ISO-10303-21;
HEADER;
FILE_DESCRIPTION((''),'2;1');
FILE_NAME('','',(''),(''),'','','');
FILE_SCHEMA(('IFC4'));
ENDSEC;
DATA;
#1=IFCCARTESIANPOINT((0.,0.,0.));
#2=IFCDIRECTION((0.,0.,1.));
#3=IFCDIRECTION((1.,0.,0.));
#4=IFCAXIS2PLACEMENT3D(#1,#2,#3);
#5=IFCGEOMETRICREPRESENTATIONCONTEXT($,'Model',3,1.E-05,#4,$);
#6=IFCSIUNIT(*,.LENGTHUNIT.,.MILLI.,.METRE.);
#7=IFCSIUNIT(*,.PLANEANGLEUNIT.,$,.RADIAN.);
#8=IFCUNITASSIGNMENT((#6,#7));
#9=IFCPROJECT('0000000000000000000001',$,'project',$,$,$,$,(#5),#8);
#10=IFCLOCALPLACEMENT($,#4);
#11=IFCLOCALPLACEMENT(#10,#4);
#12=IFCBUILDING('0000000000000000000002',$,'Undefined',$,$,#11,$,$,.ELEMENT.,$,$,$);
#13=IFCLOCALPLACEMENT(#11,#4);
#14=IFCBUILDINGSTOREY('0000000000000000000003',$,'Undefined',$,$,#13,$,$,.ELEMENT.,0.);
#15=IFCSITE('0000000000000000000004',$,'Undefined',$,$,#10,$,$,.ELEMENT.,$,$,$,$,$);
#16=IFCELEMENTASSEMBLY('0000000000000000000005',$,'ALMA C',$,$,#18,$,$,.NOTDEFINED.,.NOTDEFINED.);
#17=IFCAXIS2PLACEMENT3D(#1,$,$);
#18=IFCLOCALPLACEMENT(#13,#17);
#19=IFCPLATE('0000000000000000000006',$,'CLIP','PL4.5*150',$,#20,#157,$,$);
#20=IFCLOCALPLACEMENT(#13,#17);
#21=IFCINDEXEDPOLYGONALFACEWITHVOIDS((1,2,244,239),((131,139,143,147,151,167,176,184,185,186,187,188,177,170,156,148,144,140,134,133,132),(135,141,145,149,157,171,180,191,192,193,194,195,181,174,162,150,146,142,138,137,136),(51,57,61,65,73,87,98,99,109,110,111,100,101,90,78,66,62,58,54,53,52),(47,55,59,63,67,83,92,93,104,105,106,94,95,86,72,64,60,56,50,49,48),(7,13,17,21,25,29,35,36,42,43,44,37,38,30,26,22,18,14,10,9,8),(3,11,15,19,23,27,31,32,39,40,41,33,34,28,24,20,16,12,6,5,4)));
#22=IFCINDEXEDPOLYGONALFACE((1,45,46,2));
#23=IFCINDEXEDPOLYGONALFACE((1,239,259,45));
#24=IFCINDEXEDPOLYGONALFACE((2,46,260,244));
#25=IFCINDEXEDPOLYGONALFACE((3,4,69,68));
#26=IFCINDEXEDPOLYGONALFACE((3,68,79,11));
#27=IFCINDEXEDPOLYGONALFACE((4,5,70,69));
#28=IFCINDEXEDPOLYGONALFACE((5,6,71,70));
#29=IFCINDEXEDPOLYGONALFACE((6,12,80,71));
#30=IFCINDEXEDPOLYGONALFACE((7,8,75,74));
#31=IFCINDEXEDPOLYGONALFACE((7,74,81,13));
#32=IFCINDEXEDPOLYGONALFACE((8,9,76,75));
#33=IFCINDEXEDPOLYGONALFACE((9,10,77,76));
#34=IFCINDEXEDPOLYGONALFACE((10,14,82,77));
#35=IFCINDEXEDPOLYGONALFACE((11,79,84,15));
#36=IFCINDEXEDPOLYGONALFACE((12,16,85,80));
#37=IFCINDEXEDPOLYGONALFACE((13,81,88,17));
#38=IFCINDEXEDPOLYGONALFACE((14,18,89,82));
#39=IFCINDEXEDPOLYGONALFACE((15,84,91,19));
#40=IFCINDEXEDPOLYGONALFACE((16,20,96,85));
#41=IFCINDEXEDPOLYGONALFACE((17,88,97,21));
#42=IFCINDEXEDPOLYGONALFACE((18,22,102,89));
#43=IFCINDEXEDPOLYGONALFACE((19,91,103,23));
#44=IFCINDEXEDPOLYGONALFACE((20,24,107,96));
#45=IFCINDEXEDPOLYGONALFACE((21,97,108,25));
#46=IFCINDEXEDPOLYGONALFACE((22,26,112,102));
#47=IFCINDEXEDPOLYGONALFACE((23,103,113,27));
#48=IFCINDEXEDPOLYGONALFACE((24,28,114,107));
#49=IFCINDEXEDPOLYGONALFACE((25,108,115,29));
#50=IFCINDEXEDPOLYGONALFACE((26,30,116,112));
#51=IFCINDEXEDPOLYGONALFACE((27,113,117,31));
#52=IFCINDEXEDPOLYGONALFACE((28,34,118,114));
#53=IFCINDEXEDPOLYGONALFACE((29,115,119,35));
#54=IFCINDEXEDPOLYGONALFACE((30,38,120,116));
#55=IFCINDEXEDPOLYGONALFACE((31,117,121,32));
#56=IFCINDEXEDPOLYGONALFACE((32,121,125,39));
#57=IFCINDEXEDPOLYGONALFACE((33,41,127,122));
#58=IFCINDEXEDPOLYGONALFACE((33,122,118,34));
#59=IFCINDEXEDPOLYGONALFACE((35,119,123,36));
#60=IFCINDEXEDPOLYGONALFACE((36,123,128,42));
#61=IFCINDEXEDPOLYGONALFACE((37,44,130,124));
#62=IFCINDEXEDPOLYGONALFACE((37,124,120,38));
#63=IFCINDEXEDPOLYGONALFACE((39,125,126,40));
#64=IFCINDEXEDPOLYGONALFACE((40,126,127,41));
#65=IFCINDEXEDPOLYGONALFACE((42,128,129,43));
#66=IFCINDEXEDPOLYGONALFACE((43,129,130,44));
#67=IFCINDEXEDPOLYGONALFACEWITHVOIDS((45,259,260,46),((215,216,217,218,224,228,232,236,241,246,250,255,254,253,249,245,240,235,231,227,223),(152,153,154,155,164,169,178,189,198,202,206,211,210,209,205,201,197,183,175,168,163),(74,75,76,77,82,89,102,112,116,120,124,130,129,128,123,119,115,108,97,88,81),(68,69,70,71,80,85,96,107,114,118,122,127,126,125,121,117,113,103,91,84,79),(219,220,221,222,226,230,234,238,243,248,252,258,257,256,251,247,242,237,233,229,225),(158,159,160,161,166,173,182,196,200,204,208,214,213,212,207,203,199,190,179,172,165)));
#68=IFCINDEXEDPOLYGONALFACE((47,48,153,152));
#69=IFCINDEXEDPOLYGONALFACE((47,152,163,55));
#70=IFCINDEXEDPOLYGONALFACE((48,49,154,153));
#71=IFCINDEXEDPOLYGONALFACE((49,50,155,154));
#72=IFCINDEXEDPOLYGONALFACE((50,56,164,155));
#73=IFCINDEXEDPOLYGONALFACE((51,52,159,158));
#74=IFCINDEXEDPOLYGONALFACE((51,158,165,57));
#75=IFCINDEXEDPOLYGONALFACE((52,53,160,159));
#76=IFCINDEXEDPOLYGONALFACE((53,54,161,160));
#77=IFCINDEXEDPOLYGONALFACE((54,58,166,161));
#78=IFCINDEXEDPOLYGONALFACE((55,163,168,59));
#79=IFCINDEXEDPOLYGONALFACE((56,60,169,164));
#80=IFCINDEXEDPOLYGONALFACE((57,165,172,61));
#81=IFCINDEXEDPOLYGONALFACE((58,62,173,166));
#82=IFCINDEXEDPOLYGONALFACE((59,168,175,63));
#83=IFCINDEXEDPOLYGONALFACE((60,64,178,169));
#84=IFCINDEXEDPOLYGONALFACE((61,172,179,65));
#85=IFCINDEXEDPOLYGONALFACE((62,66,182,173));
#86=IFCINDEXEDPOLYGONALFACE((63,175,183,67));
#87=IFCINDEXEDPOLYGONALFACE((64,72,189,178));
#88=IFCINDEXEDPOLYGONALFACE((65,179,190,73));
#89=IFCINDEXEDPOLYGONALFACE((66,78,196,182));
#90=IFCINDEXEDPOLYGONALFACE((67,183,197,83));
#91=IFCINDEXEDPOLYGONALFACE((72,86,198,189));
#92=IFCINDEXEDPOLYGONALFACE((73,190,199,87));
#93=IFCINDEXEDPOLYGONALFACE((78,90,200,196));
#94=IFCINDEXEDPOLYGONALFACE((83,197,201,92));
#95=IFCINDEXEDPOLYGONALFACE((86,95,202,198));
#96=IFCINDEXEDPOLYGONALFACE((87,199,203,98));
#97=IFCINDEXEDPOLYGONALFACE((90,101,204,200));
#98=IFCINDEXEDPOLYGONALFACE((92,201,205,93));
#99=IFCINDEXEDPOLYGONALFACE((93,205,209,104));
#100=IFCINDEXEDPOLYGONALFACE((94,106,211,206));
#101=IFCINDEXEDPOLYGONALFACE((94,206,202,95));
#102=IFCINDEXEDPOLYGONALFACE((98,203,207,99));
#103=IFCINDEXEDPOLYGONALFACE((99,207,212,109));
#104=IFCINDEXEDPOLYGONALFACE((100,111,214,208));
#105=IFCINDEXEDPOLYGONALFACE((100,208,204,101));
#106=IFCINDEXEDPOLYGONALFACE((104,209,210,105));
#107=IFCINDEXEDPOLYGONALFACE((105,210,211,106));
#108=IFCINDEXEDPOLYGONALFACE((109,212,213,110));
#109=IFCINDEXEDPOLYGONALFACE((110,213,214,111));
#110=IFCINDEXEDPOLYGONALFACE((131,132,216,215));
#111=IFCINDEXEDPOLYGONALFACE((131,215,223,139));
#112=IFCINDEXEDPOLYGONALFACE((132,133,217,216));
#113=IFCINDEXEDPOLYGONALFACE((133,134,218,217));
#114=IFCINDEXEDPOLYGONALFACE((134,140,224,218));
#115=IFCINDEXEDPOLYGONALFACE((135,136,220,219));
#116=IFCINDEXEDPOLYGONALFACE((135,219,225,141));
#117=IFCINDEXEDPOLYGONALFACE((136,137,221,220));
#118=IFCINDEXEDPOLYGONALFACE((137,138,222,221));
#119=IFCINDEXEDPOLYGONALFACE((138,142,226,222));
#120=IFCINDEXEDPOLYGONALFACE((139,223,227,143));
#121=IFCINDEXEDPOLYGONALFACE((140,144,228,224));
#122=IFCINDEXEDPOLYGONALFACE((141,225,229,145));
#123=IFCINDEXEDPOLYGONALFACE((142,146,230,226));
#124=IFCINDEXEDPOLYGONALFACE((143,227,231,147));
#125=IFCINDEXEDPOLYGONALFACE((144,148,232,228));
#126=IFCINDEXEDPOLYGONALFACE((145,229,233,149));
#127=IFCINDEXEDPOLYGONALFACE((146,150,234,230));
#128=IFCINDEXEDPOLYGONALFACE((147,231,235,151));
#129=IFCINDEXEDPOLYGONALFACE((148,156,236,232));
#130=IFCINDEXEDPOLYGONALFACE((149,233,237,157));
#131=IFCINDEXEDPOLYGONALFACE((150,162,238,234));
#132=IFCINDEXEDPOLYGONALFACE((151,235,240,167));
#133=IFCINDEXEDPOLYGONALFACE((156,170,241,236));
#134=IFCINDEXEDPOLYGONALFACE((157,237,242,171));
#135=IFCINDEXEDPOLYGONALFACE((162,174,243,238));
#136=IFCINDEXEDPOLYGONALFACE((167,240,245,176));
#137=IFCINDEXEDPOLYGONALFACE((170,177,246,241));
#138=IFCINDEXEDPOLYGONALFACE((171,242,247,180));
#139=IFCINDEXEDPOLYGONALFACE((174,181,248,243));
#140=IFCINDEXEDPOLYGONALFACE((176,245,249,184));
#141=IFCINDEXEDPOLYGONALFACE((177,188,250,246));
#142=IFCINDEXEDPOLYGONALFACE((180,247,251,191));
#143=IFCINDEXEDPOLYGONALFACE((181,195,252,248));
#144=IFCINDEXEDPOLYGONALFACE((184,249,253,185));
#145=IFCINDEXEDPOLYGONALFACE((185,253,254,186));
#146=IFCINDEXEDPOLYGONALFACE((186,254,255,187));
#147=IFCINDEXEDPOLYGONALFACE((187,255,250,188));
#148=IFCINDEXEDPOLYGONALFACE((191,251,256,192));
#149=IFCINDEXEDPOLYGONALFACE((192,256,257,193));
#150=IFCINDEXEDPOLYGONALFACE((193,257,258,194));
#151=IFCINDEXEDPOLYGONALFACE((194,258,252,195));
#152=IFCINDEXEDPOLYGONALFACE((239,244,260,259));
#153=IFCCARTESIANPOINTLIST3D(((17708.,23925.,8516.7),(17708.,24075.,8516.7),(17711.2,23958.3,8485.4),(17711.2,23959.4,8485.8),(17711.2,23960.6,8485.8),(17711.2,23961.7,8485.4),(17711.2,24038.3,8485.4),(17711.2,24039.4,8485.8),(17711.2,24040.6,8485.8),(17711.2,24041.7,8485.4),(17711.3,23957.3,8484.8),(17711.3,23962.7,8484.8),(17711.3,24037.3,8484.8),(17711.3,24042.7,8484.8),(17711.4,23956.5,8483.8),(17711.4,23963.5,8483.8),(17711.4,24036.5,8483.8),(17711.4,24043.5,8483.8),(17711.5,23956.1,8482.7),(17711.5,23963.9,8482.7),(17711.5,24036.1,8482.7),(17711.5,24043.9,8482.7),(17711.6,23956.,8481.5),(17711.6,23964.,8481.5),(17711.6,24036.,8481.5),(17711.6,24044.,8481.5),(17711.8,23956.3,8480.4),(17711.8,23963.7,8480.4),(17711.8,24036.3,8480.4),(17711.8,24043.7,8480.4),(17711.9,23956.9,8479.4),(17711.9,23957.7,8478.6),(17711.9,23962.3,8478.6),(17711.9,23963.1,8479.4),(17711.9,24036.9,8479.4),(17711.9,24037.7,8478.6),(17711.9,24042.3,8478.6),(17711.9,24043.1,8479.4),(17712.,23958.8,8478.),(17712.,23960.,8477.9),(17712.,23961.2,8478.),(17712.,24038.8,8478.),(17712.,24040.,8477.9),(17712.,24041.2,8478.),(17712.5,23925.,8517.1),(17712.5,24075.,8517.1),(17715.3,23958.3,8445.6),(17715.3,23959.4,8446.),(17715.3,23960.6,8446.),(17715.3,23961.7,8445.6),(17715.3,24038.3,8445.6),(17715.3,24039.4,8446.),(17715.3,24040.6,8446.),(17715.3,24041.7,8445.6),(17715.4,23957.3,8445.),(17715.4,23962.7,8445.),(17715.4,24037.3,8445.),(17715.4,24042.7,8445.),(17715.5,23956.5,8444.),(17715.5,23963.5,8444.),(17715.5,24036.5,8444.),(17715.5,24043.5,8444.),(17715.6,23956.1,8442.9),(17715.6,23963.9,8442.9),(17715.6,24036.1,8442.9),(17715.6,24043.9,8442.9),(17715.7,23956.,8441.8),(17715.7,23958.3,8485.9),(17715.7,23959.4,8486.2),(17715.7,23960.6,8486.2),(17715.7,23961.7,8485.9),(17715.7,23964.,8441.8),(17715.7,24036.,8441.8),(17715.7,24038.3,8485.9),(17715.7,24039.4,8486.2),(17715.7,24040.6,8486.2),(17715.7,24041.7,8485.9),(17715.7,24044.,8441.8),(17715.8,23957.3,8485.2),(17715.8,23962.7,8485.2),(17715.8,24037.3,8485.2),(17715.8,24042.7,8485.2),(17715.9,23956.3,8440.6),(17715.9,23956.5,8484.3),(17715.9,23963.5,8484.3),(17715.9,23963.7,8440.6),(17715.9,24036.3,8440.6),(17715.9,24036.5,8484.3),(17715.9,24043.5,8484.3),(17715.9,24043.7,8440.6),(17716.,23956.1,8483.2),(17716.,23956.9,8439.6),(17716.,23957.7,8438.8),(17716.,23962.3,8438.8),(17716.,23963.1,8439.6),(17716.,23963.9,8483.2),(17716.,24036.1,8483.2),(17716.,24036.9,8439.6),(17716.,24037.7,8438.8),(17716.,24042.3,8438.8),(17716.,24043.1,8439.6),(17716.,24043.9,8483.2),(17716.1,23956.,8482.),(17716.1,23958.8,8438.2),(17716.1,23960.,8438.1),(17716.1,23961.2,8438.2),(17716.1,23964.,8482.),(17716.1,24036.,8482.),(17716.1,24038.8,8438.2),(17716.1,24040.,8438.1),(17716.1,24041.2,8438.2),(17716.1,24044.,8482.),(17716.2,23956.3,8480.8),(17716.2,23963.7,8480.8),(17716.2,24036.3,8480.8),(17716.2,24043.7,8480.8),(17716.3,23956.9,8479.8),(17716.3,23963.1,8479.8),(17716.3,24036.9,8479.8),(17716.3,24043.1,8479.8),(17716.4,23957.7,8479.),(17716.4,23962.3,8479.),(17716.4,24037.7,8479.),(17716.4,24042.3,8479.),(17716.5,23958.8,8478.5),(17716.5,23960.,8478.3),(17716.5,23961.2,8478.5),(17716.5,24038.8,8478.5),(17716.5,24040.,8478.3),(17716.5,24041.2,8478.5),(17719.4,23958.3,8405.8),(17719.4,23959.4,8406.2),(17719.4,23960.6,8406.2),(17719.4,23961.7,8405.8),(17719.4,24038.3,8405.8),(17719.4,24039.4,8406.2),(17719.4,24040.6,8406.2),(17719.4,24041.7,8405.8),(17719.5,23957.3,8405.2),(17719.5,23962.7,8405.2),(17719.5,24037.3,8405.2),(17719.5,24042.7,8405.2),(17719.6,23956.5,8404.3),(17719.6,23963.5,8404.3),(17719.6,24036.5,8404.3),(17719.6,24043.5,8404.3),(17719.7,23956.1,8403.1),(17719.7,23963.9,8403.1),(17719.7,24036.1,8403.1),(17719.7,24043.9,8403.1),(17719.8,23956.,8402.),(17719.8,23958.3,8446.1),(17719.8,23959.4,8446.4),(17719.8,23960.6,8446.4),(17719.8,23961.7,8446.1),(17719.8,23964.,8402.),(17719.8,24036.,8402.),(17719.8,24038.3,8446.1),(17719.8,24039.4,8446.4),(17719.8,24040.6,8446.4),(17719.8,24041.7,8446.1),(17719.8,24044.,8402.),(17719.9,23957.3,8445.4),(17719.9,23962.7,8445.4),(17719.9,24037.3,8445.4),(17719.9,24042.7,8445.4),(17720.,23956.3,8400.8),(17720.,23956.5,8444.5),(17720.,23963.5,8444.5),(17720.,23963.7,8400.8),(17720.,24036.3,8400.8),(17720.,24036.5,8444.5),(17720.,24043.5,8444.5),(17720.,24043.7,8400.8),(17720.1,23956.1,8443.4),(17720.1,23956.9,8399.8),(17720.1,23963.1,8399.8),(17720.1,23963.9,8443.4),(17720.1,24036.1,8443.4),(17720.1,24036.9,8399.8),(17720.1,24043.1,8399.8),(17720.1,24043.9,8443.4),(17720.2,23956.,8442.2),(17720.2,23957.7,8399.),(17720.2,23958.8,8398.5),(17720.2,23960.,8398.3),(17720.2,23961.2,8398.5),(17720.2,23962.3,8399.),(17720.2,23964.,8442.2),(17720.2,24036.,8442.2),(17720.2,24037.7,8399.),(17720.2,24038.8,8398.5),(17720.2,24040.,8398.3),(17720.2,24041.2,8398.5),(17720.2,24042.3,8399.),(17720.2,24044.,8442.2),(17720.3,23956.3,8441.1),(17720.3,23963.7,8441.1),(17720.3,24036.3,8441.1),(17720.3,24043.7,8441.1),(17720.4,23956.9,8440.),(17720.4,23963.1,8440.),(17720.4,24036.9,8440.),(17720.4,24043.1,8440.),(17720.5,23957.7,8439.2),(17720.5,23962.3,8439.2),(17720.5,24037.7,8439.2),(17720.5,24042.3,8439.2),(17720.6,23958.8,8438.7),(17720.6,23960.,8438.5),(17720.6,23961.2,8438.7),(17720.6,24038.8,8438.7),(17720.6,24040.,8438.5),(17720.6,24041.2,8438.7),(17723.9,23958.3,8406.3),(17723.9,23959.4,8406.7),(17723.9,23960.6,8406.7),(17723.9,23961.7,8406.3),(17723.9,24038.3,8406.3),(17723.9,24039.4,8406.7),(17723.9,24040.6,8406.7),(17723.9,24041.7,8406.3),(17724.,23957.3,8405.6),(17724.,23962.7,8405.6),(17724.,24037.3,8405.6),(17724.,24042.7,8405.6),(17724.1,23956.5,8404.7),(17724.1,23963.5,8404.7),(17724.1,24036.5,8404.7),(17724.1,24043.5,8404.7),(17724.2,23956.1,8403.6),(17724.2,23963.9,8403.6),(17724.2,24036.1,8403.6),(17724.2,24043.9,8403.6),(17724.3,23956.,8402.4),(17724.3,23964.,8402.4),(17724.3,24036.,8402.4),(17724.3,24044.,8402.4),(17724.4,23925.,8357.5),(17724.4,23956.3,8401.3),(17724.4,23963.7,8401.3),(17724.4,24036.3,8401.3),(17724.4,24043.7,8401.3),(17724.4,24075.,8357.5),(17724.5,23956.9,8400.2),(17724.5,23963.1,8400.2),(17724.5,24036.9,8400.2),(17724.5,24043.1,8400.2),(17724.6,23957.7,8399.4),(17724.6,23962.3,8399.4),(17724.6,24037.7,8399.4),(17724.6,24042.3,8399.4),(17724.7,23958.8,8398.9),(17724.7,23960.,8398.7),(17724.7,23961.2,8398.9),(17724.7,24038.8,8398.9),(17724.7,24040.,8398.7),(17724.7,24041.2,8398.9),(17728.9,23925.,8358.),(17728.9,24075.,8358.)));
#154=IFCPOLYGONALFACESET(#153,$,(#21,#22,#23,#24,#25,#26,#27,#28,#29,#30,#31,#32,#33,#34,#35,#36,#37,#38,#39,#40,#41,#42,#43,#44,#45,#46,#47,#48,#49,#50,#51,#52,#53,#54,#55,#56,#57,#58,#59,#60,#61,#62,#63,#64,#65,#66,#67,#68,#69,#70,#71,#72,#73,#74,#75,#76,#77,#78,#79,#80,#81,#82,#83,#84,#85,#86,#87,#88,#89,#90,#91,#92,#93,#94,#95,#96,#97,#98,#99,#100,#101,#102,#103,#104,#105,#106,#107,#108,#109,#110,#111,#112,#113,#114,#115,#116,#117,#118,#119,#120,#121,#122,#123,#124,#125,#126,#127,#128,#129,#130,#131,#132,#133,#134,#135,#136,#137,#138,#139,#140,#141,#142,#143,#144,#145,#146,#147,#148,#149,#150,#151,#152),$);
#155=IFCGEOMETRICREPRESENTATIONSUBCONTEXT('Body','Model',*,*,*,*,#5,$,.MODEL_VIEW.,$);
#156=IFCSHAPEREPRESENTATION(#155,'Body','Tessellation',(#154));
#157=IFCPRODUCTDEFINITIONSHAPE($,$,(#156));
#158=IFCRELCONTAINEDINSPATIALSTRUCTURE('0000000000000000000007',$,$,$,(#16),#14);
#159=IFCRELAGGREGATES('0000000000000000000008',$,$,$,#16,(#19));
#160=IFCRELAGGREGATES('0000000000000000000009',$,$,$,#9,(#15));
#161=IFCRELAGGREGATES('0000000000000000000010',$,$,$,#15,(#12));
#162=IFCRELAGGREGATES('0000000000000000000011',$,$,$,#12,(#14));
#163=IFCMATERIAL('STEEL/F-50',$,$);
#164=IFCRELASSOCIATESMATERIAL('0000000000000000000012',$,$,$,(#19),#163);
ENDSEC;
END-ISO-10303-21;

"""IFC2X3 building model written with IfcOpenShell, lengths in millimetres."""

from ifc_helpers import new_model, si_unit, frame, origin_with_axes, origin_2d_with_axis, place, context, subcontext, project, spatial, polyline, circle, outline, extrude, source, transform, mapped, material, element, aggregate, save


model = new_model("IFC2X3")

# Units and contexts
model_context = context("Model", 3, precision=1e-05, world=origin_with_axes())
body_context = subcontext(model_context, "Body", "Model", "MODEL_VIEW")
ifc_project = project(units=[si_unit("LENGTHUNIT", "METRE", prefix="MILLI"), si_unit("PLANEANGLEUNIT", "RADIAN")], contexts=[model_context])

# Site, building, storey
site_placement = place(None, origin_with_axes())
site = spatial("IfcSite", under=ifc_project, at=site_placement, Name="Undefined", CompositionType="ELEMENT")
building_placement = place(site_placement, origin_with_axes())
building = spatial("IfcBuilding", under=site, at=building_placement, Name="Undefined", CompositionType="ELEMENT")
storey_placement = place(building_placement, origin_with_axes())
storey = spatial("IfcBuildingStorey", under=building, at=storey_placement, Name="Undefined", CompositionType="ELEMENT", Elevation=0.0)

# Shared definitions
ifc_material_1 = material(Name="STEEL/F-50")

# Shared definitions
shared_shape_1 = source(origin_with_axes(), body_context, "Body", "SweptSolid", [
    extrude(circle(Radius=4.0, at=origin_2d_with_axis()), frame((0.0, -4.6, 0.0), z_axis=(0.0, 1.0, 0.0), x_axis=(1.0, 0.0, 0.0)), (0.0, 0.0, 1.0), 4.7),
])

# Element assembly, plate, openings
assembly_1_placement = place(storey_placement, origin_with_axes())
assembly_1 = element("IfcElementAssembly", 1, at=assembly_1_placement, inside=storey, Name="ALMA C", AssemblyPlace="NOTDEFINED", PredefinedType="NOTDEFINED")
plate_1_placement = place(assembly_1_placement, frame((17710.3, 23925.0, 8516.9), z_axis=(0.994727, 0.0, 0.102562), x_axis=(0.102562, 0.0, -0.994727)))
plate_1 = element("IfcPlate", 2, at=plate_1_placement, material=ifc_material_1, Name="CLIP", Description="PL4.5*150", context=body_context, shape_type="SweptSolid", body=[
    extrude(outline(polyline([(0.0, 0.0), (160.0, 0.0), (160.0, 150.0), (0.0, 150.0), (0.0, 0.0)])), frame((0.0, 0.0, -2.2), z_axis=(0.0, 0.0, 1.0), x_axis=(1.0, 0.0, 0.0)), (0.0, 0.0, 1.0), 4.5),
])
opening_1_placement = place(assembly_1_placement, frame((17711.6, 24040.0, 8481.8), z_axis=(0.0, 1.0, 0.0), x_axis=(0.102562, 0.0, -0.994727)))
element("IfcOpeningElement", 3, at=opening_1_placement, cuts=plate_1, ObjectType="Opening", context=body_context, shape_type="MappedRepresentation", body=[
    mapped(shared_shape_1, transform((0.0, 0.0, 0.0))),
    mapped(shared_shape_1, transform((40.0, 0.0, 0.0))),
    mapped(shared_shape_1, transform((80.0, 0.0, 0.0))),
])
opening_2_placement = place(assembly_1_placement, frame((17711.6, 23960.0, 8481.8), z_axis=(0.0, 1.0, 0.0), x_axis=(0.102562, 0.0, -0.994727)))
element("IfcOpeningElement", 4, at=opening_2_placement, cuts=plate_1, ObjectType="Opening", context=body_context, shape_type="MappedRepresentation", body=[
    mapped(shared_shape_1, transform((0.0, 0.0, 0.0))),
    mapped(shared_shape_1, transform((40.0, 0.0, 0.0))),
    mapped(shared_shape_1, transform((80.0, 0.0, 0.0))),
])
aggregate(assembly_1, [plate_1])

save(model, "model.ifc")
